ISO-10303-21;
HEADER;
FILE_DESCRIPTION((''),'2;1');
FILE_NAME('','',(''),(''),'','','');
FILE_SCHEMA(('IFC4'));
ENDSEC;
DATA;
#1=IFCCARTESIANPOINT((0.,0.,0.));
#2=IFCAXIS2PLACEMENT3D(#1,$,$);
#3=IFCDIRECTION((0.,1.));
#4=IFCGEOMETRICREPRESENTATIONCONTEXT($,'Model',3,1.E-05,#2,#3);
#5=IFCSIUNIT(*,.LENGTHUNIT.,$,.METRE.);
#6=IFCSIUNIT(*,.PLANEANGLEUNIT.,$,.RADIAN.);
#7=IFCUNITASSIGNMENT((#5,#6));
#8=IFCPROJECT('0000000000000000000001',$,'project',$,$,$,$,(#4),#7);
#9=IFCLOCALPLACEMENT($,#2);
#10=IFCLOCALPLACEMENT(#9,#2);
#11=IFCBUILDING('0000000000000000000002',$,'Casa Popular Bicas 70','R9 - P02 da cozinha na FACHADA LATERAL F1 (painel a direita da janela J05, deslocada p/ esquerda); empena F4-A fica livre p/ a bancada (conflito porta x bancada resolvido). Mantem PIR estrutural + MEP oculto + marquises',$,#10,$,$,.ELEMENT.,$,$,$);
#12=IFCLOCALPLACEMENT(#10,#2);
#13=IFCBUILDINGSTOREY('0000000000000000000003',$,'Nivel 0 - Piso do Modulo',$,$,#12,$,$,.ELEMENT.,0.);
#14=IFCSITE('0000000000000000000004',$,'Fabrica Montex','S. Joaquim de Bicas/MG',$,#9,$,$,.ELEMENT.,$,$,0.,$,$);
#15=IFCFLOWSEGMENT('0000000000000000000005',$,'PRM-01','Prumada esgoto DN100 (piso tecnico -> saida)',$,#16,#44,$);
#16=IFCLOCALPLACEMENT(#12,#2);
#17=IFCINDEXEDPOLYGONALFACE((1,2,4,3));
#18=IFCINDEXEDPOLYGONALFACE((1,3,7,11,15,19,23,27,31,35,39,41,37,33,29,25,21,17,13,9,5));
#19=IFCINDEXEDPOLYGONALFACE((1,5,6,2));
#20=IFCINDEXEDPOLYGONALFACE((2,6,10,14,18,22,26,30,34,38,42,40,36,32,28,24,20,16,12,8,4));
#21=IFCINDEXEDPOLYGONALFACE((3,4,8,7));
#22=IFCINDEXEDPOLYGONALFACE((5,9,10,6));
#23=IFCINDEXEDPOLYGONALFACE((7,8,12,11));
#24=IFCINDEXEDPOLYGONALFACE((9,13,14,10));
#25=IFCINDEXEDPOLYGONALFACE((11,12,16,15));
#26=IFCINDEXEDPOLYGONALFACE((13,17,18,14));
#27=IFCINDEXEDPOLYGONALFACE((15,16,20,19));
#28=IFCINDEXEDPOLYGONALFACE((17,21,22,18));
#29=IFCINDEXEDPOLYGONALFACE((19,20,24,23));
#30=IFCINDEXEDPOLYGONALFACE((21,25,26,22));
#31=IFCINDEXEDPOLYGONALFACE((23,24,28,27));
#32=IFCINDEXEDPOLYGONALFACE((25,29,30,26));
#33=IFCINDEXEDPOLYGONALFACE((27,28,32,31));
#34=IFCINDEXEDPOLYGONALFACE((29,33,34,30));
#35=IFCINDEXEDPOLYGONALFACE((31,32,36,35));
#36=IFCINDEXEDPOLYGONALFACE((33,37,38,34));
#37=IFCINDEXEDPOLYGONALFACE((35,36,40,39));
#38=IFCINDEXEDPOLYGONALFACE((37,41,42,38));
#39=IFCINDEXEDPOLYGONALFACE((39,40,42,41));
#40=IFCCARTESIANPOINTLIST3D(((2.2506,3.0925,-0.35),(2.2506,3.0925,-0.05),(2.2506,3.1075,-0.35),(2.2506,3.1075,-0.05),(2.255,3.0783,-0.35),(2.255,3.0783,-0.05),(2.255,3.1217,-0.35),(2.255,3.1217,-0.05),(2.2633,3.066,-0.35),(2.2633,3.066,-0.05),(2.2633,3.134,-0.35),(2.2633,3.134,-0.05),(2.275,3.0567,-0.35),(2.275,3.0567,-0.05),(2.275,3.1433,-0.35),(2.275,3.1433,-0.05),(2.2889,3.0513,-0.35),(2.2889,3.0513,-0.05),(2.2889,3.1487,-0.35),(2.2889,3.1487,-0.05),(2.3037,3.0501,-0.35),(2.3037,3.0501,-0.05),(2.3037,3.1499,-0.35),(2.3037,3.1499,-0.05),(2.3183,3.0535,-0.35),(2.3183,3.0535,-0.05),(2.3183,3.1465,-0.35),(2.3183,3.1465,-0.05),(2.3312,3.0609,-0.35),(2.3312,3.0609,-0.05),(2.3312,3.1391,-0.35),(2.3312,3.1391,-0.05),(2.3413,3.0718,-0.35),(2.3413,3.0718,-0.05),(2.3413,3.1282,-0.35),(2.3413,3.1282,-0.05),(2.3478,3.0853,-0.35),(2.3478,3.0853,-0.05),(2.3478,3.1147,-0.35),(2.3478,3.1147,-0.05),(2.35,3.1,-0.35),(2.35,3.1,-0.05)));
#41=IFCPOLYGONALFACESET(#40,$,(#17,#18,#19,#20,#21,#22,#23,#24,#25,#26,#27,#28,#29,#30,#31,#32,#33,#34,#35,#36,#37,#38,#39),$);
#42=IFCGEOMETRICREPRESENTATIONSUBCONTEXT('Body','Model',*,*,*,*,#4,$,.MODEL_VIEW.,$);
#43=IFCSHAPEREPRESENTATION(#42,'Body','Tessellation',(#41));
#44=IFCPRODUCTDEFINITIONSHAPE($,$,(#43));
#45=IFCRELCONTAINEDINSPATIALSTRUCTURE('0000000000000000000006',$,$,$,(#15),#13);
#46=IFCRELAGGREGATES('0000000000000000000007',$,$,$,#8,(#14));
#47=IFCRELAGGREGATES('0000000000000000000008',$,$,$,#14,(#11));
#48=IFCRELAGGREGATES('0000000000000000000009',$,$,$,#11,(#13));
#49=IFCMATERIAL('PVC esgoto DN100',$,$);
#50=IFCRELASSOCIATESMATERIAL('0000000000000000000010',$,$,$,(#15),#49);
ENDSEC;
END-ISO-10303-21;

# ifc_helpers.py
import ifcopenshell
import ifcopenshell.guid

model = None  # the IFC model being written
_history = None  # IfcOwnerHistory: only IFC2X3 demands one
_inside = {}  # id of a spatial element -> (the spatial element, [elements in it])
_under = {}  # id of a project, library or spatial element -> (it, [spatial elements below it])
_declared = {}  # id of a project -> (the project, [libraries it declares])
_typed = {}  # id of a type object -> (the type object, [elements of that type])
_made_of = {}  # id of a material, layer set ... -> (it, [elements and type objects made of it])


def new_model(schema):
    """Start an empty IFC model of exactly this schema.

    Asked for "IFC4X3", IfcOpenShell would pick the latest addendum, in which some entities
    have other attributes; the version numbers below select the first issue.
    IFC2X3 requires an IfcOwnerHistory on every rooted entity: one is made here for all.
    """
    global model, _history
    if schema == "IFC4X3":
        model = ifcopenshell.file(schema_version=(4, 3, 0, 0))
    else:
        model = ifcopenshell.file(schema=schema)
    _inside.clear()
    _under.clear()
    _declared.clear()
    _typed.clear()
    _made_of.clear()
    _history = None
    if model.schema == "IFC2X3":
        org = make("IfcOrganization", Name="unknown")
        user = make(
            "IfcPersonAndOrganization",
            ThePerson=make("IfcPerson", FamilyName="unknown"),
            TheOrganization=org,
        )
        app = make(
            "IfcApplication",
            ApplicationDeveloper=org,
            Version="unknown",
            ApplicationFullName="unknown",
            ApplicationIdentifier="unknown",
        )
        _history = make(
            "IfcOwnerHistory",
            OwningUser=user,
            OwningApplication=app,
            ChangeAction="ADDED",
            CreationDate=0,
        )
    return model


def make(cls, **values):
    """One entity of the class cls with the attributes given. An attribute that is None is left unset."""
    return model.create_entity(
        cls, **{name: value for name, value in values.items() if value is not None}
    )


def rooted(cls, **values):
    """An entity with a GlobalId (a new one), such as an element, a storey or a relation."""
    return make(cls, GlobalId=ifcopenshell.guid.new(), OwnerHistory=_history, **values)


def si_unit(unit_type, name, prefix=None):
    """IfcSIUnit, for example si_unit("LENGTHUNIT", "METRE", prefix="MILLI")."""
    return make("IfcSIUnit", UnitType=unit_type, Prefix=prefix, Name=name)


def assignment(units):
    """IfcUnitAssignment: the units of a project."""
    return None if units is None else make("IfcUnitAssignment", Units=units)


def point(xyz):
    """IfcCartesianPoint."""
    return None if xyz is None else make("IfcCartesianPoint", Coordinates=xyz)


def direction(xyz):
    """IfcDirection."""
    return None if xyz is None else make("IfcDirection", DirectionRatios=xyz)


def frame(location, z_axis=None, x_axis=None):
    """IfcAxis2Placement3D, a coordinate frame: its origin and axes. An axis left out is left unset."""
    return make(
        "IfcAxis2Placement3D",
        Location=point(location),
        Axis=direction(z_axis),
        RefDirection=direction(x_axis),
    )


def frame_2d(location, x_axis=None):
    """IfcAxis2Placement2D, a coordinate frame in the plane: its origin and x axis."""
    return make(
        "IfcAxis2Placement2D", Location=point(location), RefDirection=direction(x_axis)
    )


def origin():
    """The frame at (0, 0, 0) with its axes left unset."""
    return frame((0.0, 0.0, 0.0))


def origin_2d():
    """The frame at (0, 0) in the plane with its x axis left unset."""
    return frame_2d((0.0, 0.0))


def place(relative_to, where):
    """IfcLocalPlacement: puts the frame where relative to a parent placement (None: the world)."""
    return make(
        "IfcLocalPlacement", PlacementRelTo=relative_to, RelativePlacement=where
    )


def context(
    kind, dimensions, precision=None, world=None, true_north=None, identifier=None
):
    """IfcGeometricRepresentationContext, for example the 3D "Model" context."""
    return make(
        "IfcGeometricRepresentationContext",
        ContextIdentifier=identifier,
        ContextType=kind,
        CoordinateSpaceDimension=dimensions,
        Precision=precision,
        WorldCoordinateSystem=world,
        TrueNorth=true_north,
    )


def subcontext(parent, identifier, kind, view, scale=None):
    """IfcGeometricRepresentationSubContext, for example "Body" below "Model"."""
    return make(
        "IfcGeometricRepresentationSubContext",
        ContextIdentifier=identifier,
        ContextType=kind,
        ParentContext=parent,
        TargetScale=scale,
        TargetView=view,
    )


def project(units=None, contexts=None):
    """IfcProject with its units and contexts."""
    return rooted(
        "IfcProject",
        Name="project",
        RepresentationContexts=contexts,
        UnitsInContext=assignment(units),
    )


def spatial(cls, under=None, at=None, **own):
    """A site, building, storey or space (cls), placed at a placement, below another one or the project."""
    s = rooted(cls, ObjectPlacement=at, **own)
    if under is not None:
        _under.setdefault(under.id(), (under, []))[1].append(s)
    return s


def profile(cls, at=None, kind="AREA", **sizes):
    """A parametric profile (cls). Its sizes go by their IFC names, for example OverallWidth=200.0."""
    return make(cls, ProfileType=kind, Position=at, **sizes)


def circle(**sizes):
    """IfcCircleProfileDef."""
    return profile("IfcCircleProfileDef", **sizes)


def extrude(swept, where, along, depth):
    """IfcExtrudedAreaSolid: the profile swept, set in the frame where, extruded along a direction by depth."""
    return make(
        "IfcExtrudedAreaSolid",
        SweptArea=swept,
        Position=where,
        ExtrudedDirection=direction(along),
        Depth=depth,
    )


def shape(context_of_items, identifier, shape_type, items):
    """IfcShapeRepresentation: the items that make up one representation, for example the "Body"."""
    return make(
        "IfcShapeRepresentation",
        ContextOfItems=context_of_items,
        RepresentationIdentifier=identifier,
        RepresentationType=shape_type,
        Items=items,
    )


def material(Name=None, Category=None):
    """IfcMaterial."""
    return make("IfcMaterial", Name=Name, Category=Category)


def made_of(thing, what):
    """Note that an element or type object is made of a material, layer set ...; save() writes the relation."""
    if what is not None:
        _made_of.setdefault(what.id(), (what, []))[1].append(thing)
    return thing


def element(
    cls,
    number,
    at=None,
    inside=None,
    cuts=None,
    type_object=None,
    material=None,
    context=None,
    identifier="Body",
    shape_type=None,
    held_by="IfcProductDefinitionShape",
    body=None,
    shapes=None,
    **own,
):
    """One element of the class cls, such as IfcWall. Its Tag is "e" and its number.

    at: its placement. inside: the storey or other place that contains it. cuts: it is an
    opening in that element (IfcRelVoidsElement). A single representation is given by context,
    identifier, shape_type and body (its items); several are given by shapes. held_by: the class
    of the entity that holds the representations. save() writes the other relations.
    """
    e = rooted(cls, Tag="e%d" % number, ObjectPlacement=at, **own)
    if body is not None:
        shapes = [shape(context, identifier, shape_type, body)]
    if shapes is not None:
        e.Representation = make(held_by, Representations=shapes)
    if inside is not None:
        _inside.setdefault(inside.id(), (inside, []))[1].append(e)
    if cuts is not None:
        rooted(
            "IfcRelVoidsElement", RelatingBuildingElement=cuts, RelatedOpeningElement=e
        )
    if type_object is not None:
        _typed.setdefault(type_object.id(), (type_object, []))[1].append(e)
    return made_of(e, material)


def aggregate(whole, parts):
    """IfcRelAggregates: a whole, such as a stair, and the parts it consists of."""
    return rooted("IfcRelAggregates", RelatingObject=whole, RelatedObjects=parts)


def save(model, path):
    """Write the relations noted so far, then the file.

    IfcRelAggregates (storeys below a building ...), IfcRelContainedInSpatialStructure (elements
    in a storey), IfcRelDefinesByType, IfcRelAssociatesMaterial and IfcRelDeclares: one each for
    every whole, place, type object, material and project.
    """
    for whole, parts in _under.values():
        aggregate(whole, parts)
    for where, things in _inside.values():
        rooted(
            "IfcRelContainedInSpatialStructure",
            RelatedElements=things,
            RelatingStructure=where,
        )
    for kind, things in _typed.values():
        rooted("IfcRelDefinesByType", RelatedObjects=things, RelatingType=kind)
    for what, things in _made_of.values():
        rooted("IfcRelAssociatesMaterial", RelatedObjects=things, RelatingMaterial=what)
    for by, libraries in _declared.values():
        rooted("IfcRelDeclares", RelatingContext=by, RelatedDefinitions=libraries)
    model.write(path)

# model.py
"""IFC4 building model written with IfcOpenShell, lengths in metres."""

from ifc_helpers import new_model, si_unit, direction, frame, origin, origin_2d, place, context, subcontext, project, spatial, circle, extrude, material, element, save


model = new_model("IFC4")

# Units and contexts
model_context = context("Model", 3, precision=1e-05, world=origin(), true_north=direction((0.0, 1.0)))
body_context = subcontext(model_context, "Body", "Model", "MODEL_VIEW")
ifc_project = project(units=[si_unit("LENGTHUNIT", "METRE"), si_unit("PLANEANGLEUNIT", "RADIAN")], contexts=[model_context])

# Site, building, storey
site_placement = place(None, origin())
site = spatial("IfcSite", under=ifc_project, at=site_placement, Name="Fabrica Montex", Description="S. Joaquim de Bicas/MG", CompositionType="ELEMENT", RefElevation=0.0)
building_placement = place(site_placement, origin())
building = spatial("IfcBuilding", under=site, at=building_placement, Name="Casa Popular Bicas 70", Description="R9 - P02 da cozinha na FACHADA LATERAL F1 (painel a direita da janela J05, deslocada p/ esquerda); empena F4-A fica livre p/ a bancada (conflito porta x bancada resolvido). Mantem PIR estrutural + MEP oculto + marquises", CompositionType="ELEMENT")
storey_placement = place(building_placement, origin())
storey = spatial("IfcBuildingStorey", under=building, at=storey_placement, Name="Nivel 0 - Piso do Modulo", CompositionType="ELEMENT", Elevation=0.0)

# Flow segment
ifc_material_1 = material(Name="PVC esgoto DN100")
flow_segment_placement = place(storey_placement, frame((2.3, 3.1, -0.35)))
element("IfcFlowSegment", 1, at=flow_segment_placement, inside=storey, material=ifc_material_1, Name="PRM-01", Description="Prumada esgoto DN100 (piso tecnico -> saida)", context=body_context, shape_type="SweptSolid", body=[
    extrude(circle(Radius=0.05, at=origin_2d()), origin(), (0.0, 0.0, 1.0), 0.3),
])

save(model, "model.ifc")
